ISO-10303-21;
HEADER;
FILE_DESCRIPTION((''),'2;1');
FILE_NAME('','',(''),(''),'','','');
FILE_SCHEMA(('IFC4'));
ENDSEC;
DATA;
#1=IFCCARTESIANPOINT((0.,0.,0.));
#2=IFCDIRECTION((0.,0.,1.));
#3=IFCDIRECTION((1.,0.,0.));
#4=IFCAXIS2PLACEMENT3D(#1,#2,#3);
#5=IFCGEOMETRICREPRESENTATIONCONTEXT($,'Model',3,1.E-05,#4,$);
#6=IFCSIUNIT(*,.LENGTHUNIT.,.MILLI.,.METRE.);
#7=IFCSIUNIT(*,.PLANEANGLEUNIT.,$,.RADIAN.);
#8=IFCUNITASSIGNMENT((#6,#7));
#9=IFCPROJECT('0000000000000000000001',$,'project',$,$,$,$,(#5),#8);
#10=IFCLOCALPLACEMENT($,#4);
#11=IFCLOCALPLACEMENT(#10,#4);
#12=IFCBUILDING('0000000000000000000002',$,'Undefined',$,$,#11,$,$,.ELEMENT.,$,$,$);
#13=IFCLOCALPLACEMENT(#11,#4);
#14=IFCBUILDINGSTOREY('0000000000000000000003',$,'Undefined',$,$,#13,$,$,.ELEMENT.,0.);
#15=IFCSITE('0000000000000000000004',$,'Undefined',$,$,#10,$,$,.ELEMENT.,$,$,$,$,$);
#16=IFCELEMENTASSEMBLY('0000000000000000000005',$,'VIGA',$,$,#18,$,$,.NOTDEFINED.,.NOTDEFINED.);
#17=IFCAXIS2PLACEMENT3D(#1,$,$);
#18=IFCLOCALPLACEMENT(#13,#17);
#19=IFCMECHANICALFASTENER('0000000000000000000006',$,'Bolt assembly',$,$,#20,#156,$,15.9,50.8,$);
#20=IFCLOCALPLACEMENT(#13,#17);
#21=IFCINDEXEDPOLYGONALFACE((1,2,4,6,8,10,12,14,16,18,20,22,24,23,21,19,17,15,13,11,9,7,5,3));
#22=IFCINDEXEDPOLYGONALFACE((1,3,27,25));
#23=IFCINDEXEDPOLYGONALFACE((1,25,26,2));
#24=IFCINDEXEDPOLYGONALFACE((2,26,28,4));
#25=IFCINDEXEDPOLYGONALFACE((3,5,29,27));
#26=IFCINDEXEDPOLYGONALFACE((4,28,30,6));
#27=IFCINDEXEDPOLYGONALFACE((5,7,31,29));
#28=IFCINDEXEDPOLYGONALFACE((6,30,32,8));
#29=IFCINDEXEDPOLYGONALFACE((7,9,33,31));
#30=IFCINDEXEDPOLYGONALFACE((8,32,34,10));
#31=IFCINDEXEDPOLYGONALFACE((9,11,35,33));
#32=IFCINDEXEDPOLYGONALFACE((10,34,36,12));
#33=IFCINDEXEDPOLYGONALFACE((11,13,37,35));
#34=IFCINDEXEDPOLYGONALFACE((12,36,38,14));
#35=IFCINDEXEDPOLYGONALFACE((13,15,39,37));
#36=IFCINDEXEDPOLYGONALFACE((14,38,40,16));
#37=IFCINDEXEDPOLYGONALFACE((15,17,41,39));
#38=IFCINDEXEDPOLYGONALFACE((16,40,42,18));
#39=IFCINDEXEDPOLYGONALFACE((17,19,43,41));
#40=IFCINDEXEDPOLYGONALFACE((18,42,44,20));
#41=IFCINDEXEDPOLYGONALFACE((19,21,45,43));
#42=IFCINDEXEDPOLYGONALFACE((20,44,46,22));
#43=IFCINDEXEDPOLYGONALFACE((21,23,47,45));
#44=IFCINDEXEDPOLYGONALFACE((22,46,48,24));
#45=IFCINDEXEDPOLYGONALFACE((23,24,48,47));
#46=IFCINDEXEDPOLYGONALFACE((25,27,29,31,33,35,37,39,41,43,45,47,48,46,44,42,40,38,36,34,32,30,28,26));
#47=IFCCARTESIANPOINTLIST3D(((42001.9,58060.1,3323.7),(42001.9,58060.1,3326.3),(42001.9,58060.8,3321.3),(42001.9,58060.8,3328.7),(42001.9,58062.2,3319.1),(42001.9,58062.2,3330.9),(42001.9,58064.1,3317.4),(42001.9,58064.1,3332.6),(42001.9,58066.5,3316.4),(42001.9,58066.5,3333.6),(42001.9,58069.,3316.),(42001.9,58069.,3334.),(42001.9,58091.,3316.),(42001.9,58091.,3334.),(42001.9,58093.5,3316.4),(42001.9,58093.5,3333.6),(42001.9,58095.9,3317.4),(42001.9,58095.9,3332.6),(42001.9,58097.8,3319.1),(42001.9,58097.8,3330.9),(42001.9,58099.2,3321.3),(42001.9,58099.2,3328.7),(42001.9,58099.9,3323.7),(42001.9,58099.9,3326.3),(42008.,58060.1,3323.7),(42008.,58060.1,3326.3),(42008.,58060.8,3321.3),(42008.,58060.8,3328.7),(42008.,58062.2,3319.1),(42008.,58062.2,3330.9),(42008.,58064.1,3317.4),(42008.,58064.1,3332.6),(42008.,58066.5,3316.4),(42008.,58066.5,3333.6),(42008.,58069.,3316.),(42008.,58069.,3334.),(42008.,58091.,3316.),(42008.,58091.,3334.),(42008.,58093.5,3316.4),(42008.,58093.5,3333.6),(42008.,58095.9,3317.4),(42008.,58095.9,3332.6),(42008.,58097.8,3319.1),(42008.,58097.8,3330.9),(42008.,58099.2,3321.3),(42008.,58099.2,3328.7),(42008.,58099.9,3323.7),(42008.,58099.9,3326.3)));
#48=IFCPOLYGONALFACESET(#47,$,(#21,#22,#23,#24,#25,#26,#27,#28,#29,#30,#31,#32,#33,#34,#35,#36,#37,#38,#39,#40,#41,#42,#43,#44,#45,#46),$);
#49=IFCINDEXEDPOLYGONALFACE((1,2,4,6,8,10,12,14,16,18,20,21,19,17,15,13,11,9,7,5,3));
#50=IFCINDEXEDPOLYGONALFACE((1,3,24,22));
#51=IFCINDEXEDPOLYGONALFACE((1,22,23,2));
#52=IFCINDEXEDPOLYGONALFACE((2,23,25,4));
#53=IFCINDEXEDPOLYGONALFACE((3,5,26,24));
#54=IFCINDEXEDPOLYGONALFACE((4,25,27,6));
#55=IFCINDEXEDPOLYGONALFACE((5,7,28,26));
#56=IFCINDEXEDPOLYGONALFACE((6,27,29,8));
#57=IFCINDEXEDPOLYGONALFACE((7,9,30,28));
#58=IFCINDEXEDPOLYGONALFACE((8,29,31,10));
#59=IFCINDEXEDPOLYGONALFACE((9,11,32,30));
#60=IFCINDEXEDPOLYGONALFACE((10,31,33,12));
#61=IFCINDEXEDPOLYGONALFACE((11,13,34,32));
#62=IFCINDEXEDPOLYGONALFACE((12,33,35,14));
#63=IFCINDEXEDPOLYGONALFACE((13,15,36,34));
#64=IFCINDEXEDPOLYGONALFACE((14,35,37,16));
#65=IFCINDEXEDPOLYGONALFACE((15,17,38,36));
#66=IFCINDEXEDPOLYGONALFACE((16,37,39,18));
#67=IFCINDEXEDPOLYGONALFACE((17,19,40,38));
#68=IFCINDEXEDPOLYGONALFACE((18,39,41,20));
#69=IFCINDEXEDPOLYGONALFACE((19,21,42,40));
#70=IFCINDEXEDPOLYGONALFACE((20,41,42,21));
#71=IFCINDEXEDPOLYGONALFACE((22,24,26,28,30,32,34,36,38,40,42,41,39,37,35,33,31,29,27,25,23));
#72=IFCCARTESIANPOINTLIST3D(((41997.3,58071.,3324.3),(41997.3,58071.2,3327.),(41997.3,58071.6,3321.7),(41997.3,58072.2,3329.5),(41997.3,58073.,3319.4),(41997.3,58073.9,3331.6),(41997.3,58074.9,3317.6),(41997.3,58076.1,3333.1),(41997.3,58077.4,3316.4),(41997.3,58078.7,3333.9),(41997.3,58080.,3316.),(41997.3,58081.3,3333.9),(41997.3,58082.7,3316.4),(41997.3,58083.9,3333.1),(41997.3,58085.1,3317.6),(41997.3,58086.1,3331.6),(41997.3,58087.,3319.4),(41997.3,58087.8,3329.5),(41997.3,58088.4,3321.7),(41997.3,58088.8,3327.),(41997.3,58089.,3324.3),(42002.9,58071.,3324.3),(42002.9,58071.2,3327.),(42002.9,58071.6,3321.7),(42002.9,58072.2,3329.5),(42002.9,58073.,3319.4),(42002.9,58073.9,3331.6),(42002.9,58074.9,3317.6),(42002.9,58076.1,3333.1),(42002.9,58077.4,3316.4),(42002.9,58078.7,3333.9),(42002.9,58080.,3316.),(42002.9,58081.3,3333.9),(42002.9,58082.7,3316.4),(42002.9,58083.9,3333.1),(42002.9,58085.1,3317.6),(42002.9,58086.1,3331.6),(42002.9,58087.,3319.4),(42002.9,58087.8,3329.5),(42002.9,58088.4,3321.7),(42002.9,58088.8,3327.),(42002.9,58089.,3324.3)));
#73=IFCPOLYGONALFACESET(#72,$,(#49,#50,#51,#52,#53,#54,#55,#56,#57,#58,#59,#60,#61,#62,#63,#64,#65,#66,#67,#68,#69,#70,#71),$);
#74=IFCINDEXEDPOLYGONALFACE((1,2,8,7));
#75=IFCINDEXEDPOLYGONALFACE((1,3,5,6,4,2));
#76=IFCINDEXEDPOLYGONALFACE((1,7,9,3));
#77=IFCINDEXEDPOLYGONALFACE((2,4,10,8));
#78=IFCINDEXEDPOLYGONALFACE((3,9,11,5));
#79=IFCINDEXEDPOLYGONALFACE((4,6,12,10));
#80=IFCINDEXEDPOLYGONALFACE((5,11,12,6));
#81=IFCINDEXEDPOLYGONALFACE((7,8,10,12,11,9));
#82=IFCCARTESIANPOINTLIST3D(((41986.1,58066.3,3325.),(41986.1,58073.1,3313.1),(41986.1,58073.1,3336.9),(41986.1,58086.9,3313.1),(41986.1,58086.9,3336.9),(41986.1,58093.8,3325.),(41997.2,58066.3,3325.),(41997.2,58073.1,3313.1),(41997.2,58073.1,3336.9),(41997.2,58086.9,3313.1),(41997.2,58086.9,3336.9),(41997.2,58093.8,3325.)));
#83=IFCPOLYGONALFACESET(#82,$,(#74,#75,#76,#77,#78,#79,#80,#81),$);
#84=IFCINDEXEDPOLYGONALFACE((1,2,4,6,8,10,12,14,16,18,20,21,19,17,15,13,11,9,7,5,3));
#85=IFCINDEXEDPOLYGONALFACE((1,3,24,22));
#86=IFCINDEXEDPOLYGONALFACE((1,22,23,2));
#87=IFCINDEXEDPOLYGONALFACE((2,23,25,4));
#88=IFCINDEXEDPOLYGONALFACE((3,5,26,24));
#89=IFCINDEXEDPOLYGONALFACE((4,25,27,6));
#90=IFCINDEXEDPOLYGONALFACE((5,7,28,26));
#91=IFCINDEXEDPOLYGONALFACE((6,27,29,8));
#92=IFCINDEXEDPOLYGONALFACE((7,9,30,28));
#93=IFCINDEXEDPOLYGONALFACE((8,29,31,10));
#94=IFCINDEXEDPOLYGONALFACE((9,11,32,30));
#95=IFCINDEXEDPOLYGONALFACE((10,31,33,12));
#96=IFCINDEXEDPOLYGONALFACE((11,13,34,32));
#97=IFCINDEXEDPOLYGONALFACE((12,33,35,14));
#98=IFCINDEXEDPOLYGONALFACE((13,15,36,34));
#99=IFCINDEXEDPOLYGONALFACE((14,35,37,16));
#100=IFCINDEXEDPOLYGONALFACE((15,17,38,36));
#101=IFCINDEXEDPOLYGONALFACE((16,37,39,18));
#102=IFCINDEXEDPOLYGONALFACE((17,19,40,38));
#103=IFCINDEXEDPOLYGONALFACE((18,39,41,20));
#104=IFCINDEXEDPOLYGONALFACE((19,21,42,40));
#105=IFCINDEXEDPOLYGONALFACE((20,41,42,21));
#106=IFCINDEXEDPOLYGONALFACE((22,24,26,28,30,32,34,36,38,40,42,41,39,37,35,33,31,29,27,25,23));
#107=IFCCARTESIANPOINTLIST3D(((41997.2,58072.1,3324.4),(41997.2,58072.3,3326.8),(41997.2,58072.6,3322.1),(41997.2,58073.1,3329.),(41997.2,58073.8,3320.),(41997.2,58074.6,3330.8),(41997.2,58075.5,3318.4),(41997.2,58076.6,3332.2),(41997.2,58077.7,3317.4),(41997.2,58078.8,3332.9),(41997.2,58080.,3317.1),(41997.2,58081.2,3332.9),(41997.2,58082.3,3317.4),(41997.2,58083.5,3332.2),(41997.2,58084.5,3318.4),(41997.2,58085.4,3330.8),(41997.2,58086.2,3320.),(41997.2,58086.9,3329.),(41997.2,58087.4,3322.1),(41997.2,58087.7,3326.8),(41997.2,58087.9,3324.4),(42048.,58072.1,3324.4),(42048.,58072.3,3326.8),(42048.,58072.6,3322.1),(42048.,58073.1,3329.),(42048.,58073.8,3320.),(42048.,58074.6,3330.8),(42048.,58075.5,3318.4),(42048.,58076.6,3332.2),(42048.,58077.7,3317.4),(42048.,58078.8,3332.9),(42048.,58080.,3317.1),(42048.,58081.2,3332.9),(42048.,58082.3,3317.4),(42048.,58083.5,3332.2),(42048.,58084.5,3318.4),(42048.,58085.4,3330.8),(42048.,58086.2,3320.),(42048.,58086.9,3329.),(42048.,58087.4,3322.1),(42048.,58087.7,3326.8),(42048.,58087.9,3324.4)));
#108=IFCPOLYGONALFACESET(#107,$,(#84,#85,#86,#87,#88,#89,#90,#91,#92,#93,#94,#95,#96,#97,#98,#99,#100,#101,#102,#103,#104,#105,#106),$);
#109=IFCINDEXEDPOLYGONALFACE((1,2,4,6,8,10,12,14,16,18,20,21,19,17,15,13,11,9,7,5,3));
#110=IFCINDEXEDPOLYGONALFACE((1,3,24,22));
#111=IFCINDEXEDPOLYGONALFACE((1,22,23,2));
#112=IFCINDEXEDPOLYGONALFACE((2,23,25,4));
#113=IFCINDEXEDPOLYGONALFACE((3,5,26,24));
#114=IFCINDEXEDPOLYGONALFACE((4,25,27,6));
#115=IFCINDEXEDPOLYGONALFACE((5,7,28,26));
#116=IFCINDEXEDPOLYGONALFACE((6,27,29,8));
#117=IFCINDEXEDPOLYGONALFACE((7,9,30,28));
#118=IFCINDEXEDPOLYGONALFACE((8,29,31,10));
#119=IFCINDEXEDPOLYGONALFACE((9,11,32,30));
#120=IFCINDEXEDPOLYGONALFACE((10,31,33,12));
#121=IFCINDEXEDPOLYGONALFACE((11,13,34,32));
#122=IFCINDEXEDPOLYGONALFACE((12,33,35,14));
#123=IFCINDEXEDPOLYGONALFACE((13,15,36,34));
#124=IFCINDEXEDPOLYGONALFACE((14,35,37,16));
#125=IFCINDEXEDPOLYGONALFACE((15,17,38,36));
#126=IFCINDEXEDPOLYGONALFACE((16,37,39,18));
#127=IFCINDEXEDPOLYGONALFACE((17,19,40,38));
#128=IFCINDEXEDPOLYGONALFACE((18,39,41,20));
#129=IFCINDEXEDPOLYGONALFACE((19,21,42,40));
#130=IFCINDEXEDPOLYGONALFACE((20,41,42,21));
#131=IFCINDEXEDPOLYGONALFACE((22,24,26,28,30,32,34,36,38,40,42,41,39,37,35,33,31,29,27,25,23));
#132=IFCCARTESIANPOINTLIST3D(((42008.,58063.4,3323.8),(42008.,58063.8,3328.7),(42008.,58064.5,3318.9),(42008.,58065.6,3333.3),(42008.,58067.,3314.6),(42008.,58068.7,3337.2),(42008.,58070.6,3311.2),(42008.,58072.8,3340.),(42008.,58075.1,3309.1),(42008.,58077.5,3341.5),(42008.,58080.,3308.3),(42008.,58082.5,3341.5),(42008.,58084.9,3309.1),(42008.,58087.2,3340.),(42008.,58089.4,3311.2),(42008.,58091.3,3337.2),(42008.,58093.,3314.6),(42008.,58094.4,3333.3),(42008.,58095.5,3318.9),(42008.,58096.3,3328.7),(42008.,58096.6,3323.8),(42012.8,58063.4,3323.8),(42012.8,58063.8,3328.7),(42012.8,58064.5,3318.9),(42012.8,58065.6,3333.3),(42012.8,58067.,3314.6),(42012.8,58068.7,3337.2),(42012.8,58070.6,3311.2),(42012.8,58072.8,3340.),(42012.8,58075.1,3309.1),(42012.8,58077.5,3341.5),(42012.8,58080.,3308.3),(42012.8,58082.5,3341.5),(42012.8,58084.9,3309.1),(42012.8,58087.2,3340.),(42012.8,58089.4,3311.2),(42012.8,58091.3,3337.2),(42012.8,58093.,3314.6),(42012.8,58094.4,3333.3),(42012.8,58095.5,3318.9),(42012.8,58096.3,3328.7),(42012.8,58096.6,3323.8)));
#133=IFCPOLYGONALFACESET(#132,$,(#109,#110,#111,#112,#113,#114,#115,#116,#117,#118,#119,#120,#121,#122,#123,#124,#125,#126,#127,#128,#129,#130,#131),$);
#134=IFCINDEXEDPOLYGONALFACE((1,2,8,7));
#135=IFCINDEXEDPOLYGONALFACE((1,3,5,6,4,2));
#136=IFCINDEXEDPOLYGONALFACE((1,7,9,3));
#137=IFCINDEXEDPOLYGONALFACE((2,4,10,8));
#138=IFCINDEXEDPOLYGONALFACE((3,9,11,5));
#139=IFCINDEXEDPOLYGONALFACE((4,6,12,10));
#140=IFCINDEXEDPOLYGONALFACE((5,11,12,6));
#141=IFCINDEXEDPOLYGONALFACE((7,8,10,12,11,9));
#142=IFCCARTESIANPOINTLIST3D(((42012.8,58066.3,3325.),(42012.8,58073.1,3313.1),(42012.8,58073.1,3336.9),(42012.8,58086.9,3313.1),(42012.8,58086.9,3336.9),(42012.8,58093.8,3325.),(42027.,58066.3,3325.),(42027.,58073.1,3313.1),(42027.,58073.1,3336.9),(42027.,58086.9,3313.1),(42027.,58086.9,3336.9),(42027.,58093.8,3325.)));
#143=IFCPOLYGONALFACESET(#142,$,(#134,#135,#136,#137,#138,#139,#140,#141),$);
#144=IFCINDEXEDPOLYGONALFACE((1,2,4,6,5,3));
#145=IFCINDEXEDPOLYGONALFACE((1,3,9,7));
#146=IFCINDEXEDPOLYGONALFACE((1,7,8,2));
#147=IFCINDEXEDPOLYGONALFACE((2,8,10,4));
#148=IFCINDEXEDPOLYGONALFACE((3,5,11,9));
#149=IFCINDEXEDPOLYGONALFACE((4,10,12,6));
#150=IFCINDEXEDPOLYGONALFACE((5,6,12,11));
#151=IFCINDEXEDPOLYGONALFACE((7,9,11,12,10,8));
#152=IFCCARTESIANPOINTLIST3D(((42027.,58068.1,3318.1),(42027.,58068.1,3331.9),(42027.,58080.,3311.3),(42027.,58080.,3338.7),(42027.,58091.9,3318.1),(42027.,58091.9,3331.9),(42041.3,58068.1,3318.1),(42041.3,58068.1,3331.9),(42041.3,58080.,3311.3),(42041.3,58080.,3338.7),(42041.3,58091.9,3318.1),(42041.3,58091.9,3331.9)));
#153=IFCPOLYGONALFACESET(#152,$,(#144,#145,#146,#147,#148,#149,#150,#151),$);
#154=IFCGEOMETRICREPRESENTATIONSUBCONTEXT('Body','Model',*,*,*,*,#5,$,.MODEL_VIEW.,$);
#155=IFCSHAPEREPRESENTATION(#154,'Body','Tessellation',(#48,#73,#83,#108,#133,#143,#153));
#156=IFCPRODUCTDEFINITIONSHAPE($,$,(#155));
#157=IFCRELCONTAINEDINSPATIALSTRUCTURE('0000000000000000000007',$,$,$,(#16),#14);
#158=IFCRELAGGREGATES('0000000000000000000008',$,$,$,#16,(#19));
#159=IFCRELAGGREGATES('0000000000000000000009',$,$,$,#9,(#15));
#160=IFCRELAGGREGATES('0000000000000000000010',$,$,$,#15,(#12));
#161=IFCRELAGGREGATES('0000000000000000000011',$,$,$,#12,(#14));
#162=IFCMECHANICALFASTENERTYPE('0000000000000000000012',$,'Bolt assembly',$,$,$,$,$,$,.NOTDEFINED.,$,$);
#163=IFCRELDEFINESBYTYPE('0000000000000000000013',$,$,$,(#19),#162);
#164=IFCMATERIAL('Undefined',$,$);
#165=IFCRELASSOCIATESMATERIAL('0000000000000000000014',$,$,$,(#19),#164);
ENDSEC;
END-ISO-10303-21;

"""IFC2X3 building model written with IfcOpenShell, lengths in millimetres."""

from ifc_helpers import new_model, si_unit, frame, frame_2d, origin_with_axes, origin_2d_with_axis, place, context, subcontext, project, spatial, polyline, circle_curve, parameter, trimmed, segment, composite_curve, circle, outline, extrude, source, transform, mapped, material, type_object, element, aggregate, save


model = new_model("IFC2X3")

# Units and contexts
model_context = context("Model", 3, precision=1e-05, world=origin_with_axes())
body_context = subcontext(model_context, "Body", "Model", "MODEL_VIEW")
ifc_project = project(units=[si_unit("LENGTHUNIT", "METRE", prefix="MILLI"), si_unit("PLANEANGLEUNIT", "RADIAN")], contexts=[model_context])

# Site, building, storey
site_placement = place(None, origin_with_axes())
site = spatial("IfcSite", under=ifc_project, at=site_placement, Name="Undefined", CompositionType="ELEMENT")
building_placement = place(site_placement, origin_with_axes())
building = spatial("IfcBuilding", under=site, at=building_placement, Name="Undefined", CompositionType="ELEMENT")
storey_placement = place(building_placement, origin_with_axes())
storey = spatial("IfcBuildingStorey", under=building, at=storey_placement, Name="Undefined", CompositionType="ELEMENT", Elevation=0.0)

# Element assembly
assembly_1_placement = place(storey_placement, origin_with_axes())
assembly_1 = element("IfcElementAssembly", 1, at=assembly_1_placement, inside=storey, Name="VIGA", AssemblyPlace="NOTDEFINED", PredefinedType="NOTDEFINED")

# Mechanical fastener
ifc_material_1 = material(Name="Undefined")
mechanical_fastener_type = type_object("IfcMechanicalFastenerType", Name="Bolt assembly")
shared_shape_1 = source(origin_with_axes(), body_context, "Body", "SweptSolid", [
    extrude(outline(composite_curve([segment(polyline([(9.0, 11.0), (9.0, -11.0)]), True, "CONTINUOUS"), segment(trimmed(circle_curve(frame_2d((0.0, -11.0), x_axis=(1.0, 0.0)), 9.0), [parameter(0.0)], [parameter(3.141593)], False, "PARAMETER"), True, "CONTINUOUS"), segment(polyline([(-9.0, -11.0), (-9.0, 11.0)]), True, "CONTINUOUS"), segment(trimmed(circle_curve(frame_2d((0.0, 11.0), x_axis=(-1.0, 0.0)), 9.0), [parameter(0.0)], [parameter(3.141593)], False, "PARAMETER"), True, "DISCONTINUOUS")], self_intersect=False)), frame((0.0, 1.9, 0.0), z_axis=(0.0, 1.0, 0.0), x_axis=(1.0, 0.0, 0.0)), (0.0, 0.0, 1.0), 6.1),
    extrude(circle(Radius=9.0, at=origin_2d_with_axis()), frame((0.0, -2.7, 0.0), z_axis=(0.0, 1.0, 0.0), x_axis=(1.0, 0.0, 0.0)), (0.0, 0.0, 1.0), 5.6),
    extrude(outline(polyline([(11.9, -6.9), (11.9, 6.9), (0.0, 13.7), (-11.9, 6.9), (-11.9, -6.9), (0.0, -13.7), (11.9, -6.9)])), frame((0.0, -13.9, 0.0), z_axis=(0.0, 1.0, 0.0), x_axis=(1.0, 0.0, 0.0)), (0.0, 0.0, 1.0), 11.1),
    extrude(circle(Radius=7.9, at=origin_2d_with_axis()), frame((0.0, -2.8, 0.0), z_axis=(0.0, 1.0, 0.0), x_axis=(1.0, 0.0, 0.0)), (0.0, 0.0, 1.0), 50.8),
    extrude(circle(Radius=16.7, at=origin_2d_with_axis()), frame((0.0, 8.0, 0.0), z_axis=(0.0, 1.0, 0.0), x_axis=(1.0, 0.0, 0.0)), (0.0, 0.0, 1.0), 4.8),
    extrude(outline(polyline([(11.9, -6.9), (11.9, 6.9), (0.0, 13.7), (-11.9, 6.9), (-11.9, -6.9), (0.0, -13.7), (11.9, -6.9)])), frame((0.0, 12.8, 0.0), z_axis=(0.0, 1.0, 0.0), x_axis=(1.0, 0.0, 0.0)), (0.0, 0.0, 1.0), 14.3),
    extrude(outline(polyline([(13.7, 0.0), (6.9, 11.9), (-6.9, 11.9), (-13.7, 0.0), (-6.9, -11.9), (6.9, -11.9), (13.7, 0.0)])), frame((0.0, 27.0, 0.0), z_axis=(0.0, 1.0, 0.0), x_axis=(1.0, 0.0, 0.0)), (0.0, 0.0, 1.0), 14.3),
])
mechanical_fastener_1_placement = place(assembly_1_placement, frame((42000.0, 58080.0, 3325.0), z_axis=(0.0, -1.0, 0.0), x_axis=(0.0, 0.0, -1.0)))
mechanical_fastener_1 = element("IfcMechanicalFastener", 2, at=mechanical_fastener_1_placement, type_object=mechanical_fastener_type, material=ifc_material_1, Name="Bolt assembly", NominalDiameter=15.9, NominalLength=50.8, context=body_context, shape_type="MappedRepresentation", body=[
    mapped(shared_shape_1, transform((0.0, 0.0, 0.0))),
])
aggregate(assembly_1, [mechanical_fastener_1])

save(model, "model.ifc")
